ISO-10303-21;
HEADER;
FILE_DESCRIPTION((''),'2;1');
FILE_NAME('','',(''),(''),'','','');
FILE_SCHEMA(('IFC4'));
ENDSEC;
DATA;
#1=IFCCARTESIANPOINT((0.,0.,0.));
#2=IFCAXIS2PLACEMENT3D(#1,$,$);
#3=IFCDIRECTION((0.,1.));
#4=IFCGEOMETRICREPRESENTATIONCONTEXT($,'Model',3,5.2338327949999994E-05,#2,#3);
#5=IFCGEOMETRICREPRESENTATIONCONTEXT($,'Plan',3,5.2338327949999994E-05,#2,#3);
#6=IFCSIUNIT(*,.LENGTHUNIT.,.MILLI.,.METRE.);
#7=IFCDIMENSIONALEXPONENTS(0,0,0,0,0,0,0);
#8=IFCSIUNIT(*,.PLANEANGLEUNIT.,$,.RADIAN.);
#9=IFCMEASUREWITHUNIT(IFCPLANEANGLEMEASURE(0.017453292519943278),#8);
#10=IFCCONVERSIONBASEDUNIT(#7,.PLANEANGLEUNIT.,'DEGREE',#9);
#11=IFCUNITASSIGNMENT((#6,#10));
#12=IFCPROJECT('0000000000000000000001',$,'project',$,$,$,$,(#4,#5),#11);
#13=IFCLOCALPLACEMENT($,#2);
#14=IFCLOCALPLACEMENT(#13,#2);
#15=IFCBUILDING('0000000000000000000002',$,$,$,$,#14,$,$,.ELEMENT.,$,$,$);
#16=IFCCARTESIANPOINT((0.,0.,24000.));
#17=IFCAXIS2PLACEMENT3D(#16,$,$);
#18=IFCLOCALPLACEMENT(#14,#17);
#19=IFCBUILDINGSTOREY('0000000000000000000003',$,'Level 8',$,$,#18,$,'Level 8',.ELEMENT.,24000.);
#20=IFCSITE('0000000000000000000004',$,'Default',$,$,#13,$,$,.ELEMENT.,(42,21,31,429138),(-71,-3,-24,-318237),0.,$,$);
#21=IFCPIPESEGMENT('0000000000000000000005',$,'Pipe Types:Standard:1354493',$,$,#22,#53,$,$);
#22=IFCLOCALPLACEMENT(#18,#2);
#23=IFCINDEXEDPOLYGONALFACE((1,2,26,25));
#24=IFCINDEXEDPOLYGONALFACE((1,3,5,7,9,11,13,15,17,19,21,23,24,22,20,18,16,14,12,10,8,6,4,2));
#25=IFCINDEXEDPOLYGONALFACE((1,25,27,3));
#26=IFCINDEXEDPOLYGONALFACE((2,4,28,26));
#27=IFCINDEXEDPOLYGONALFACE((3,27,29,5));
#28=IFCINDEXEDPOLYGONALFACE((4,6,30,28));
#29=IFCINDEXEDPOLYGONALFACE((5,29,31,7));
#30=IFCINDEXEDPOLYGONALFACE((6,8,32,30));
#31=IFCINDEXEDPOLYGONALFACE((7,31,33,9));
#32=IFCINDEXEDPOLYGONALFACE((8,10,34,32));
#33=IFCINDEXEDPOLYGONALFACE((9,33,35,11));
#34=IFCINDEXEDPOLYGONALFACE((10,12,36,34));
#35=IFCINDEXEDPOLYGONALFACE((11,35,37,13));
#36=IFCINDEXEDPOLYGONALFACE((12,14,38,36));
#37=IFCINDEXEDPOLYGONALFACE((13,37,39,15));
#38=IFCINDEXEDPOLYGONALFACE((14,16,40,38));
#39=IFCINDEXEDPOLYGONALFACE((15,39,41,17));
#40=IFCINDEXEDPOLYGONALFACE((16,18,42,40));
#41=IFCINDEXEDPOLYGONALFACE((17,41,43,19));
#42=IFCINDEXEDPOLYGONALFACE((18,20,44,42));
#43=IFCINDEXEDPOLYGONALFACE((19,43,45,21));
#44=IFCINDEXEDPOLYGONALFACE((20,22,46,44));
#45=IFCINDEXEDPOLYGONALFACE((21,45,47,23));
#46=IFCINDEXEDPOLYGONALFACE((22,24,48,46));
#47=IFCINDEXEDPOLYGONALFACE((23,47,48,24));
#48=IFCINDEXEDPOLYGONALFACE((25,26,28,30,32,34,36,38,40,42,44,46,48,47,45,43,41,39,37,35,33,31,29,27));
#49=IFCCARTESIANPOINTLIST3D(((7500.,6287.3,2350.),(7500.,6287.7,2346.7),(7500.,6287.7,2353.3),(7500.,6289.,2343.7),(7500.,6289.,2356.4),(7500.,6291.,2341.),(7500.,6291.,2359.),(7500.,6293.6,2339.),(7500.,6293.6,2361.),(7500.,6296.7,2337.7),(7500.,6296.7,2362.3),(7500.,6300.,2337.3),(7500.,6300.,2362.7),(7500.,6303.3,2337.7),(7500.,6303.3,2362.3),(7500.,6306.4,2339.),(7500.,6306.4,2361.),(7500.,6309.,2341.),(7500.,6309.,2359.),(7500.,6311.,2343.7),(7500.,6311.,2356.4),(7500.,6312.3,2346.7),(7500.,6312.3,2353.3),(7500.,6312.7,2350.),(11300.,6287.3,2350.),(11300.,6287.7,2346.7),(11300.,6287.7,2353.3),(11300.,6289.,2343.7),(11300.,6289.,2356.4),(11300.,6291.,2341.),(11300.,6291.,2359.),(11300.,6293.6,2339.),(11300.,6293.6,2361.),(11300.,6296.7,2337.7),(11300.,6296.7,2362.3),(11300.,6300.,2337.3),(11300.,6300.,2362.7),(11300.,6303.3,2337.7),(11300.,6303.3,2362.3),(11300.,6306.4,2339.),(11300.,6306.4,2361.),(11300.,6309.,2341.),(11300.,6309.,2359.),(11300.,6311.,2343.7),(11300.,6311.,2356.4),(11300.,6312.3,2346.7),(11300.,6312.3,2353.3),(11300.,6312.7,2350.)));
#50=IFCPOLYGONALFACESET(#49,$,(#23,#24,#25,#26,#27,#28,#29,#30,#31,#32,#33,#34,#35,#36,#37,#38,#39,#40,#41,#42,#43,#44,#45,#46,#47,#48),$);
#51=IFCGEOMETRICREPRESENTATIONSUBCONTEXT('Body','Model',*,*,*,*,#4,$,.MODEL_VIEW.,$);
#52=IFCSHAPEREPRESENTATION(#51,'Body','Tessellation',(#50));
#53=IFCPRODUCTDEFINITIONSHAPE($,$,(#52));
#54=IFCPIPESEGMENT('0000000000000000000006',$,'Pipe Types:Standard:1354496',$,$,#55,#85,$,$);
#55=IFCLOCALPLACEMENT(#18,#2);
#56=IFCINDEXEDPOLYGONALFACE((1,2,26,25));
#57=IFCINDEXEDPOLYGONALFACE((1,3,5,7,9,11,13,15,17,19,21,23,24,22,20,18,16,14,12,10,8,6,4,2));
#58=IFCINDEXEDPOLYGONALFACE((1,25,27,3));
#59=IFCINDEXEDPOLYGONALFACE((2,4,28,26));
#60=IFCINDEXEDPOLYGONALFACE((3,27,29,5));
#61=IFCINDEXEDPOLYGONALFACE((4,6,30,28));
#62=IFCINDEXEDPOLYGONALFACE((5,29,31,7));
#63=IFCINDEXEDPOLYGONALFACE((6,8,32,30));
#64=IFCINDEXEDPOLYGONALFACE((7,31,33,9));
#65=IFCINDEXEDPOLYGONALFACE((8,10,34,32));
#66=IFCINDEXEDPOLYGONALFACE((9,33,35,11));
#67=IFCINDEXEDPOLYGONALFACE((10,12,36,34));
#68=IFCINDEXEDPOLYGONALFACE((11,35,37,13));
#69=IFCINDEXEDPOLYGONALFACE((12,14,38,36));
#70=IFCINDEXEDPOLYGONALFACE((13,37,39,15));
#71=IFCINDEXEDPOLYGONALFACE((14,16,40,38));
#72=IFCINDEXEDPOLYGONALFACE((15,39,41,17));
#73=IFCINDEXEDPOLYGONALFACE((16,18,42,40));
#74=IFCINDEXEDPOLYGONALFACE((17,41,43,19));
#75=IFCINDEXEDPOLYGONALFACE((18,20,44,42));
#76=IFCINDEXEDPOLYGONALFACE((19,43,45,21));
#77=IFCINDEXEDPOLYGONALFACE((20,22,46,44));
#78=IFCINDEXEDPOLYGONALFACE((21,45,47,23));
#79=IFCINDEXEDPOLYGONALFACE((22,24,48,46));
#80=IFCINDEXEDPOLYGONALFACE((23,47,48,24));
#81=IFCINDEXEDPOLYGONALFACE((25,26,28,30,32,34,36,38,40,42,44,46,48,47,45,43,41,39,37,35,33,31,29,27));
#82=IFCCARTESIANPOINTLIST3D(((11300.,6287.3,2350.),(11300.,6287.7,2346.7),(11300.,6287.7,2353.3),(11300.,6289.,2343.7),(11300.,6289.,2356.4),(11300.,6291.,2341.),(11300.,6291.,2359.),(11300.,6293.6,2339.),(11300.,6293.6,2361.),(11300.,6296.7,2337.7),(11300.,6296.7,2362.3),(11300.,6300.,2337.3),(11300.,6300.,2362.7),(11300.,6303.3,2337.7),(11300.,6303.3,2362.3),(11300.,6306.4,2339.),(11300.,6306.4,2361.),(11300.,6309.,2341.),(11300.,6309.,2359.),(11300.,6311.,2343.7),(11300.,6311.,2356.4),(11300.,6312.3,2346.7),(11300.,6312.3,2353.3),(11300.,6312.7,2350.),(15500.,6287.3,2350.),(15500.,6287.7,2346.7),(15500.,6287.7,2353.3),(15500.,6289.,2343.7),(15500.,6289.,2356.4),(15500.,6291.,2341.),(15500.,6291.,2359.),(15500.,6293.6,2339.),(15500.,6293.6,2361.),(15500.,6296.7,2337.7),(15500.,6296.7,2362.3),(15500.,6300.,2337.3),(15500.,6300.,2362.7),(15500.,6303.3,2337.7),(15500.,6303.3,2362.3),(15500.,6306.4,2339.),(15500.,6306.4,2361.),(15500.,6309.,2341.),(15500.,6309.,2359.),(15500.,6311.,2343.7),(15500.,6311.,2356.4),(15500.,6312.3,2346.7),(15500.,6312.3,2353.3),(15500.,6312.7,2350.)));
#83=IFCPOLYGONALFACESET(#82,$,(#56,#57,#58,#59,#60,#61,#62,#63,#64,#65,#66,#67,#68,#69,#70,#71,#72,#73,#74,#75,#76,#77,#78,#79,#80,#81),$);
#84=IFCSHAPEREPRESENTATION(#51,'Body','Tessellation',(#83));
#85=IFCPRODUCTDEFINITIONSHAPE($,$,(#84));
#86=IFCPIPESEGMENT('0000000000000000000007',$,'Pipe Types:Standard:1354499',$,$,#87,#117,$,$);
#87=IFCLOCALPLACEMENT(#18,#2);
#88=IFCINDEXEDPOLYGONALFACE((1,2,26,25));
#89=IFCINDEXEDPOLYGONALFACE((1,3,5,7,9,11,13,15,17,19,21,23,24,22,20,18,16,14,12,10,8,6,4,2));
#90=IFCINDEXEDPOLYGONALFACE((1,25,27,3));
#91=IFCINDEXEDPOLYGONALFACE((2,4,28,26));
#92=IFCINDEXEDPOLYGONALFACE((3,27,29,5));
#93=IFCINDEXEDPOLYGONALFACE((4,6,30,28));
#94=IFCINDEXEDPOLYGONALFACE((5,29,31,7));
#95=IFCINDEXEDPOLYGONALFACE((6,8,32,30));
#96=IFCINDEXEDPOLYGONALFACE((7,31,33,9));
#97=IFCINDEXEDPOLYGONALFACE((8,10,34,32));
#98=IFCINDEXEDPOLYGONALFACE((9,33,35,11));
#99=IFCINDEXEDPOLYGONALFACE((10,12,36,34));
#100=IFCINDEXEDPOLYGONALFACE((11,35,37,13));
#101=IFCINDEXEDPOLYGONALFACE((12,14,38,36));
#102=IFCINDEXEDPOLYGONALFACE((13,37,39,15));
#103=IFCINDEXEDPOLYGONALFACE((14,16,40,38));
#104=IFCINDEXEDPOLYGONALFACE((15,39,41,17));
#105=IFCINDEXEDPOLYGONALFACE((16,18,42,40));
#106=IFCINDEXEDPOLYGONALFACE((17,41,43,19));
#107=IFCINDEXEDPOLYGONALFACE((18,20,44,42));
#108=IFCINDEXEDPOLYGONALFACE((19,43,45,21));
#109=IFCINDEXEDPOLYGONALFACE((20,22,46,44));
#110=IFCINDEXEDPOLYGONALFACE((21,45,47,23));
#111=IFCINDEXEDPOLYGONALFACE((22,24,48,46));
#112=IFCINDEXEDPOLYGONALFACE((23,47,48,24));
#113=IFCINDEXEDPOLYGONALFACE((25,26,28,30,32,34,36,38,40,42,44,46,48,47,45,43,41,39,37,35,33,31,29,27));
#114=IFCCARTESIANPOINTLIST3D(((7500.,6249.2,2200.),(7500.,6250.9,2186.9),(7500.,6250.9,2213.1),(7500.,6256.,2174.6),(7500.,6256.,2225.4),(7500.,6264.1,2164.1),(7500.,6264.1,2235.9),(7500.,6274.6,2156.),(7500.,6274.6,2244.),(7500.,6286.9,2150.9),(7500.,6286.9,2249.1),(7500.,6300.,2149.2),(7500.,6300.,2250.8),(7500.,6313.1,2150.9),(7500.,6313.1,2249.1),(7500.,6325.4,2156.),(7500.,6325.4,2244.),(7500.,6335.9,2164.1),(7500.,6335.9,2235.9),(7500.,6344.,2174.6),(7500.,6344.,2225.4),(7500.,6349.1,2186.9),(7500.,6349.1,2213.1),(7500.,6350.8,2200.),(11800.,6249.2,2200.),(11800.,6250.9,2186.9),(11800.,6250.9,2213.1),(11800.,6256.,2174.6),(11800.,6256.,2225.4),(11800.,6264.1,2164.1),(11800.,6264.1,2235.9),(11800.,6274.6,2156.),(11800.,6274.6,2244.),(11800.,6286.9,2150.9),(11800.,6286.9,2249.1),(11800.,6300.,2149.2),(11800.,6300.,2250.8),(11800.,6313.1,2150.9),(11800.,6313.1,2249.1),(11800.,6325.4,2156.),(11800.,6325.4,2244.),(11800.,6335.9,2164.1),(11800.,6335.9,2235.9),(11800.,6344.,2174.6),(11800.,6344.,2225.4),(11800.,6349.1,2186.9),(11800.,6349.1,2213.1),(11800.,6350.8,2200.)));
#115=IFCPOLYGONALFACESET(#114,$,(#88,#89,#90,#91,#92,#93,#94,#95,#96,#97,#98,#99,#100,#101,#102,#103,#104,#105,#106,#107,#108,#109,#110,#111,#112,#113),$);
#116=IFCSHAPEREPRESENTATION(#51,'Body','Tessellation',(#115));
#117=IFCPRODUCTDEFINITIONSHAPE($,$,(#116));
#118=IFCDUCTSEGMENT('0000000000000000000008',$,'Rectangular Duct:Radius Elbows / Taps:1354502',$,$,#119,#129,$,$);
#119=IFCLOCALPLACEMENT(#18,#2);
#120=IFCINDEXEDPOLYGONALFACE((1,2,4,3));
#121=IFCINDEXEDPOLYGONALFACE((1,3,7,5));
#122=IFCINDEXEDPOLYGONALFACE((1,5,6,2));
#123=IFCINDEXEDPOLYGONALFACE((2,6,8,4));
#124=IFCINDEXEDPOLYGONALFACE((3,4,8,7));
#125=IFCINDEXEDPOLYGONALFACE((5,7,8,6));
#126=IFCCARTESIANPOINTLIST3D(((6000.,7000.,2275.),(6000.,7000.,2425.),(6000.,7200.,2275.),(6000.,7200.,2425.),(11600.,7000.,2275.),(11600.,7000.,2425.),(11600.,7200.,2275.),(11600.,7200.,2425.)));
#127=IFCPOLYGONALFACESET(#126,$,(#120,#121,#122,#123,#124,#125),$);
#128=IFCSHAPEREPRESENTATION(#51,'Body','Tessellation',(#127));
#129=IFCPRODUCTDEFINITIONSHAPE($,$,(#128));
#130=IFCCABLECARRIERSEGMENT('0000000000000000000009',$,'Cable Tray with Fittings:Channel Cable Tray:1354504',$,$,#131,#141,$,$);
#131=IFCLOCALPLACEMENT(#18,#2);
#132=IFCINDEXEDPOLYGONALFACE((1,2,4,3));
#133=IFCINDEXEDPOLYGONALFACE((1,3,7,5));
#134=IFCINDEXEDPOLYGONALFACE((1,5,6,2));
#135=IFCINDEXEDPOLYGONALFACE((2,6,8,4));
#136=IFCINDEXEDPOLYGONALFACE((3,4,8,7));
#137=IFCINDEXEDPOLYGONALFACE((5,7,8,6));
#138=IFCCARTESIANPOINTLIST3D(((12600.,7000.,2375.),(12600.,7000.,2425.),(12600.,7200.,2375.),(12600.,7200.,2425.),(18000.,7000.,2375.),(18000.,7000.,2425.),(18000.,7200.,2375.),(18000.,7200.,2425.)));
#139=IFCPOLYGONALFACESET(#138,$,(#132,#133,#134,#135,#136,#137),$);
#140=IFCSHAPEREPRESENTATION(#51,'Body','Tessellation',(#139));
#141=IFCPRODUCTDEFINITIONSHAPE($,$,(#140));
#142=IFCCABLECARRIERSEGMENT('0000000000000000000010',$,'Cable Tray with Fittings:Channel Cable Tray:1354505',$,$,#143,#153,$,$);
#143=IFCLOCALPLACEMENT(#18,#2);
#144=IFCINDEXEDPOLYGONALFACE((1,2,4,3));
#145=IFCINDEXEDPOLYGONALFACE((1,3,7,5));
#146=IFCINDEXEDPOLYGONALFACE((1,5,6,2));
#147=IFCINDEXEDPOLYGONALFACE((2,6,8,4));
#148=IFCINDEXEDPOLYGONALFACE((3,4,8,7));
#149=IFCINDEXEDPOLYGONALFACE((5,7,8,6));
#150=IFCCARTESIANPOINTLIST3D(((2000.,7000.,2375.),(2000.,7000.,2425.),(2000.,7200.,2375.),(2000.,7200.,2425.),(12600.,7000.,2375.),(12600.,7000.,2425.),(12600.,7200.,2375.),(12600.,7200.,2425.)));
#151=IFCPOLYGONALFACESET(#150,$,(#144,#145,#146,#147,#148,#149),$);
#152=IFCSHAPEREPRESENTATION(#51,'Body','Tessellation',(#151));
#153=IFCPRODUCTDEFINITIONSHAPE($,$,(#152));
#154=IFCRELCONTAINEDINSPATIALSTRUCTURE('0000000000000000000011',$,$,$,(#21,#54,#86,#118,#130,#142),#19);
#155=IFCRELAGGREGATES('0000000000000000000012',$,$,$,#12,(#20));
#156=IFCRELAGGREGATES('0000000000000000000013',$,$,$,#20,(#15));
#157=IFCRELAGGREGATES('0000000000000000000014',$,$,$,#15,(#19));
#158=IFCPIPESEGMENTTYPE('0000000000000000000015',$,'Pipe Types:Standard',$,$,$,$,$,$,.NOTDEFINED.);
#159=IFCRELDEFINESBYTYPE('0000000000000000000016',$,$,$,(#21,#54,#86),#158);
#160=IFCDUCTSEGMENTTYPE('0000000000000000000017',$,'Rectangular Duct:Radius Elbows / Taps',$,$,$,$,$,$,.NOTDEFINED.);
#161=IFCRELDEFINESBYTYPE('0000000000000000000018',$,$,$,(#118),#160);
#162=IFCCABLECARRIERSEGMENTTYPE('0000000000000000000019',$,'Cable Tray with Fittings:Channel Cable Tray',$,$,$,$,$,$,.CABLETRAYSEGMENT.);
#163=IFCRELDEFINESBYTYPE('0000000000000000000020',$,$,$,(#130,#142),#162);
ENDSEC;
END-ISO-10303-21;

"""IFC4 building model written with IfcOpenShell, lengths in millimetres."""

from ifc_helpers import new_model, entity, si_unit, converted_unit, direction, frame, origin, place, context, subcontext, project, spatial, arc, indexed_curve, outline, extrude, type_object, element, save


model = new_model("IFC4")

# Units and contexts
model_context = context("Model", 3, precision=5.2338327949999994e-05, world=origin(), true_north=direction((0.0, 1.0)))
plan_context = context("Plan", 3, precision=5.2338327949999994e-05, world=origin(), true_north=direction((0.0, 1.0)))
body_context = subcontext(model_context, "Body", "Model", "MODEL_VIEW")
ifc_project = project(units=[si_unit("LENGTHUNIT", "METRE", prefix="MILLI"), converted_unit("PLANEANGLEUNIT", "DEGREE", entity("IfcPlaneAngleMeasure", 0.017453292519943278), si_unit("PLANEANGLEUNIT", "RADIAN"), dimensions=[0, 0, 0, 0, 0, 0, 0])], contexts=[model_context, plan_context])

# Site, building, storey
site_placement = place(None, origin())
site = spatial("IfcSite", under=ifc_project, at=site_placement, Name="Default", CompositionType="ELEMENT", RefLatitude=(42, 21, 31, 429138), RefLongitude=(-71, -3, -24, -318237), RefElevation=0.0)
building_placement = place(site_placement, origin())
building = spatial("IfcBuilding", under=site, at=building_placement, CompositionType="ELEMENT")
storey_placement = place(building_placement, frame((0.0, 0.0, 24000.0)))
storey = spatial("IfcBuildingStorey", under=building, at=storey_placement, Name="Level 8", LongName="Level 8", CompositionType="ELEMENT", Elevation=24000.0)

# Pipe segments
pipe_segment_type = type_object("IfcPipeSegmentType", Name="Pipe Types:Standard", PredefinedType="NOTDEFINED")
pipe_segment_1_placement = place(storey_placement, origin())
element("IfcPipeSegment", 1, at=pipe_segment_1_placement, inside=storey, type_object=pipe_segment_type, Name="Pipe Types:Standard:1354493", context=body_context, shape_type="SweptSolid", body=[
    extrude(outline(indexed_curve([(12.7, 0.0), (9.0, 9.0), (0.0, 12.7), (-9.0, 9.0), (-12.7, 0.0), (-9.0, -9.0), (0.0, -12.7), (9.0, -9.0)], segments=[arc(1, 2, 3), arc(3, 4, 5), arc(5, 6, 7), arc(7, 8, 1)], self_intersect=False)), frame((7500.0, 6300.0, 2350.0), z_axis=(1.0, 0.0, 0.0), x_axis=(0.0, 1.0, 0.0)), (0.0, 0.0, 1.0), 3800.0),
])
pipe_segment_2_placement = place(storey_placement, origin())
element("IfcPipeSegment", 2, at=pipe_segment_2_placement, inside=storey, type_object=pipe_segment_type, Name="Pipe Types:Standard:1354496", context=body_context, shape_type="SweptSolid", body=[
    extrude(outline(indexed_curve([(12.7, 0.0), (9.0, 9.0), (0.0, 12.7), (-9.0, 9.0), (-12.7, 0.0), (-9.0, -9.0), (0.0, -12.7), (9.0, -9.0)], segments=[arc(1, 2, 3), arc(3, 4, 5), arc(5, 6, 7), arc(7, 8, 1)], self_intersect=False)), frame((11300.0, 6300.0, 2350.0), z_axis=(1.0, 0.0, 0.0), x_axis=(0.0, -1.0, 0.0)), (0.0, 0.0, 1.0), 4200.0),
])
pipe_segment_3_placement = place(storey_placement, origin())
element("IfcPipeSegment", 3, at=pipe_segment_3_placement, inside=storey, type_object=pipe_segment_type, Name="Pipe Types:Standard:1354499", context=body_context, shape_type="SweptSolid", body=[
    extrude(outline(indexed_curve([(50.8, 0.0), (35.9, 35.9), (0.0, 50.8), (-35.9, 35.9), (-50.8, 0.0), (-35.9, -35.9), (0.0, -50.8), (35.9, -35.9)], segments=[arc(1, 2, 3), arc(3, 4, 5), arc(5, 6, 7), arc(7, 8, 1)], self_intersect=False)), frame((7500.0, 6300.0, 2200.0), z_axis=(1.0, 0.0, 0.0), x_axis=(0.0, 1.0, 0.0)), (0.0, 0.0, 1.0), 4300.0),
])

# Duct segment
duct_segment_type = type_object("IfcDuctSegmentType", Name="Rectangular Duct:Radius Elbows / Taps", PredefinedType="NOTDEFINED")
duct_segment_placement = place(storey_placement, origin())
element("IfcDuctSegment", 4, at=duct_segment_placement, inside=storey, type_object=duct_segment_type, Name="Rectangular Duct:Radius Elbows / Taps:1354502", context=body_context, shape_type="SweptSolid", body=[
    extrude(outline(indexed_curve([(-2800.0, -100.0), (2800.0, -100.0), (2800.0, 100.0), (-2800.0, 100.0), (-2800.0, -100.0)], self_intersect=False)), frame((8800.0, 7100.0, 2275.0), z_axis=(0.0, 0.0, 1.0), x_axis=(-1.0, 0.0, 0.0)), (0.0, 0.0, 1.0), 150.0),
])

# Cable carrier segments
cable_carrier_segment_type = type_object("IfcCableCarrierSegmentType", Name="Cable Tray with Fittings:Channel Cable Tray", PredefinedType="CABLETRAYSEGMENT")
cable_carrier_segment_1_placement = place(storey_placement, origin())
element("IfcCableCarrierSegment", 5, at=cable_carrier_segment_1_placement, inside=storey, type_object=cable_carrier_segment_type, Name="Cable Tray with Fittings:Channel Cable Tray:1354504", context=body_context, shape_type="SweptSolid", body=[
    extrude(outline(indexed_curve([(-2700.0, -100.0), (2700.0, -100.0), (2700.0, 100.0), (-2700.0, 100.0), (-2700.0, -100.0)], self_intersect=False)), frame((15300.0, 7100.0, 2375.0)), (0.0, 0.0, 1.0), 50.0),
])
cable_carrier_segment_2_placement = place(storey_placement, origin())
element("IfcCableCarrierSegment", 6, at=cable_carrier_segment_2_placement, inside=storey, type_object=cable_carrier_segment_type, Name="Cable Tray with Fittings:Channel Cable Tray:1354505", context=body_context, shape_type="SweptSolid", body=[
    extrude(outline(indexed_curve([(-5300.0, -100.0), (5300.0, -100.0), (5300.0, 100.0), (-5300.0, 100.0), (-5300.0, -100.0)], self_intersect=False)), frame((7300.0, 7100.0, 2375.0), z_axis=(0.0, 0.0, 1.0), x_axis=(-1.0, 0.0, 0.0)), (0.0, 0.0, 1.0), 50.0),
])

save(model, "model.ifc")
